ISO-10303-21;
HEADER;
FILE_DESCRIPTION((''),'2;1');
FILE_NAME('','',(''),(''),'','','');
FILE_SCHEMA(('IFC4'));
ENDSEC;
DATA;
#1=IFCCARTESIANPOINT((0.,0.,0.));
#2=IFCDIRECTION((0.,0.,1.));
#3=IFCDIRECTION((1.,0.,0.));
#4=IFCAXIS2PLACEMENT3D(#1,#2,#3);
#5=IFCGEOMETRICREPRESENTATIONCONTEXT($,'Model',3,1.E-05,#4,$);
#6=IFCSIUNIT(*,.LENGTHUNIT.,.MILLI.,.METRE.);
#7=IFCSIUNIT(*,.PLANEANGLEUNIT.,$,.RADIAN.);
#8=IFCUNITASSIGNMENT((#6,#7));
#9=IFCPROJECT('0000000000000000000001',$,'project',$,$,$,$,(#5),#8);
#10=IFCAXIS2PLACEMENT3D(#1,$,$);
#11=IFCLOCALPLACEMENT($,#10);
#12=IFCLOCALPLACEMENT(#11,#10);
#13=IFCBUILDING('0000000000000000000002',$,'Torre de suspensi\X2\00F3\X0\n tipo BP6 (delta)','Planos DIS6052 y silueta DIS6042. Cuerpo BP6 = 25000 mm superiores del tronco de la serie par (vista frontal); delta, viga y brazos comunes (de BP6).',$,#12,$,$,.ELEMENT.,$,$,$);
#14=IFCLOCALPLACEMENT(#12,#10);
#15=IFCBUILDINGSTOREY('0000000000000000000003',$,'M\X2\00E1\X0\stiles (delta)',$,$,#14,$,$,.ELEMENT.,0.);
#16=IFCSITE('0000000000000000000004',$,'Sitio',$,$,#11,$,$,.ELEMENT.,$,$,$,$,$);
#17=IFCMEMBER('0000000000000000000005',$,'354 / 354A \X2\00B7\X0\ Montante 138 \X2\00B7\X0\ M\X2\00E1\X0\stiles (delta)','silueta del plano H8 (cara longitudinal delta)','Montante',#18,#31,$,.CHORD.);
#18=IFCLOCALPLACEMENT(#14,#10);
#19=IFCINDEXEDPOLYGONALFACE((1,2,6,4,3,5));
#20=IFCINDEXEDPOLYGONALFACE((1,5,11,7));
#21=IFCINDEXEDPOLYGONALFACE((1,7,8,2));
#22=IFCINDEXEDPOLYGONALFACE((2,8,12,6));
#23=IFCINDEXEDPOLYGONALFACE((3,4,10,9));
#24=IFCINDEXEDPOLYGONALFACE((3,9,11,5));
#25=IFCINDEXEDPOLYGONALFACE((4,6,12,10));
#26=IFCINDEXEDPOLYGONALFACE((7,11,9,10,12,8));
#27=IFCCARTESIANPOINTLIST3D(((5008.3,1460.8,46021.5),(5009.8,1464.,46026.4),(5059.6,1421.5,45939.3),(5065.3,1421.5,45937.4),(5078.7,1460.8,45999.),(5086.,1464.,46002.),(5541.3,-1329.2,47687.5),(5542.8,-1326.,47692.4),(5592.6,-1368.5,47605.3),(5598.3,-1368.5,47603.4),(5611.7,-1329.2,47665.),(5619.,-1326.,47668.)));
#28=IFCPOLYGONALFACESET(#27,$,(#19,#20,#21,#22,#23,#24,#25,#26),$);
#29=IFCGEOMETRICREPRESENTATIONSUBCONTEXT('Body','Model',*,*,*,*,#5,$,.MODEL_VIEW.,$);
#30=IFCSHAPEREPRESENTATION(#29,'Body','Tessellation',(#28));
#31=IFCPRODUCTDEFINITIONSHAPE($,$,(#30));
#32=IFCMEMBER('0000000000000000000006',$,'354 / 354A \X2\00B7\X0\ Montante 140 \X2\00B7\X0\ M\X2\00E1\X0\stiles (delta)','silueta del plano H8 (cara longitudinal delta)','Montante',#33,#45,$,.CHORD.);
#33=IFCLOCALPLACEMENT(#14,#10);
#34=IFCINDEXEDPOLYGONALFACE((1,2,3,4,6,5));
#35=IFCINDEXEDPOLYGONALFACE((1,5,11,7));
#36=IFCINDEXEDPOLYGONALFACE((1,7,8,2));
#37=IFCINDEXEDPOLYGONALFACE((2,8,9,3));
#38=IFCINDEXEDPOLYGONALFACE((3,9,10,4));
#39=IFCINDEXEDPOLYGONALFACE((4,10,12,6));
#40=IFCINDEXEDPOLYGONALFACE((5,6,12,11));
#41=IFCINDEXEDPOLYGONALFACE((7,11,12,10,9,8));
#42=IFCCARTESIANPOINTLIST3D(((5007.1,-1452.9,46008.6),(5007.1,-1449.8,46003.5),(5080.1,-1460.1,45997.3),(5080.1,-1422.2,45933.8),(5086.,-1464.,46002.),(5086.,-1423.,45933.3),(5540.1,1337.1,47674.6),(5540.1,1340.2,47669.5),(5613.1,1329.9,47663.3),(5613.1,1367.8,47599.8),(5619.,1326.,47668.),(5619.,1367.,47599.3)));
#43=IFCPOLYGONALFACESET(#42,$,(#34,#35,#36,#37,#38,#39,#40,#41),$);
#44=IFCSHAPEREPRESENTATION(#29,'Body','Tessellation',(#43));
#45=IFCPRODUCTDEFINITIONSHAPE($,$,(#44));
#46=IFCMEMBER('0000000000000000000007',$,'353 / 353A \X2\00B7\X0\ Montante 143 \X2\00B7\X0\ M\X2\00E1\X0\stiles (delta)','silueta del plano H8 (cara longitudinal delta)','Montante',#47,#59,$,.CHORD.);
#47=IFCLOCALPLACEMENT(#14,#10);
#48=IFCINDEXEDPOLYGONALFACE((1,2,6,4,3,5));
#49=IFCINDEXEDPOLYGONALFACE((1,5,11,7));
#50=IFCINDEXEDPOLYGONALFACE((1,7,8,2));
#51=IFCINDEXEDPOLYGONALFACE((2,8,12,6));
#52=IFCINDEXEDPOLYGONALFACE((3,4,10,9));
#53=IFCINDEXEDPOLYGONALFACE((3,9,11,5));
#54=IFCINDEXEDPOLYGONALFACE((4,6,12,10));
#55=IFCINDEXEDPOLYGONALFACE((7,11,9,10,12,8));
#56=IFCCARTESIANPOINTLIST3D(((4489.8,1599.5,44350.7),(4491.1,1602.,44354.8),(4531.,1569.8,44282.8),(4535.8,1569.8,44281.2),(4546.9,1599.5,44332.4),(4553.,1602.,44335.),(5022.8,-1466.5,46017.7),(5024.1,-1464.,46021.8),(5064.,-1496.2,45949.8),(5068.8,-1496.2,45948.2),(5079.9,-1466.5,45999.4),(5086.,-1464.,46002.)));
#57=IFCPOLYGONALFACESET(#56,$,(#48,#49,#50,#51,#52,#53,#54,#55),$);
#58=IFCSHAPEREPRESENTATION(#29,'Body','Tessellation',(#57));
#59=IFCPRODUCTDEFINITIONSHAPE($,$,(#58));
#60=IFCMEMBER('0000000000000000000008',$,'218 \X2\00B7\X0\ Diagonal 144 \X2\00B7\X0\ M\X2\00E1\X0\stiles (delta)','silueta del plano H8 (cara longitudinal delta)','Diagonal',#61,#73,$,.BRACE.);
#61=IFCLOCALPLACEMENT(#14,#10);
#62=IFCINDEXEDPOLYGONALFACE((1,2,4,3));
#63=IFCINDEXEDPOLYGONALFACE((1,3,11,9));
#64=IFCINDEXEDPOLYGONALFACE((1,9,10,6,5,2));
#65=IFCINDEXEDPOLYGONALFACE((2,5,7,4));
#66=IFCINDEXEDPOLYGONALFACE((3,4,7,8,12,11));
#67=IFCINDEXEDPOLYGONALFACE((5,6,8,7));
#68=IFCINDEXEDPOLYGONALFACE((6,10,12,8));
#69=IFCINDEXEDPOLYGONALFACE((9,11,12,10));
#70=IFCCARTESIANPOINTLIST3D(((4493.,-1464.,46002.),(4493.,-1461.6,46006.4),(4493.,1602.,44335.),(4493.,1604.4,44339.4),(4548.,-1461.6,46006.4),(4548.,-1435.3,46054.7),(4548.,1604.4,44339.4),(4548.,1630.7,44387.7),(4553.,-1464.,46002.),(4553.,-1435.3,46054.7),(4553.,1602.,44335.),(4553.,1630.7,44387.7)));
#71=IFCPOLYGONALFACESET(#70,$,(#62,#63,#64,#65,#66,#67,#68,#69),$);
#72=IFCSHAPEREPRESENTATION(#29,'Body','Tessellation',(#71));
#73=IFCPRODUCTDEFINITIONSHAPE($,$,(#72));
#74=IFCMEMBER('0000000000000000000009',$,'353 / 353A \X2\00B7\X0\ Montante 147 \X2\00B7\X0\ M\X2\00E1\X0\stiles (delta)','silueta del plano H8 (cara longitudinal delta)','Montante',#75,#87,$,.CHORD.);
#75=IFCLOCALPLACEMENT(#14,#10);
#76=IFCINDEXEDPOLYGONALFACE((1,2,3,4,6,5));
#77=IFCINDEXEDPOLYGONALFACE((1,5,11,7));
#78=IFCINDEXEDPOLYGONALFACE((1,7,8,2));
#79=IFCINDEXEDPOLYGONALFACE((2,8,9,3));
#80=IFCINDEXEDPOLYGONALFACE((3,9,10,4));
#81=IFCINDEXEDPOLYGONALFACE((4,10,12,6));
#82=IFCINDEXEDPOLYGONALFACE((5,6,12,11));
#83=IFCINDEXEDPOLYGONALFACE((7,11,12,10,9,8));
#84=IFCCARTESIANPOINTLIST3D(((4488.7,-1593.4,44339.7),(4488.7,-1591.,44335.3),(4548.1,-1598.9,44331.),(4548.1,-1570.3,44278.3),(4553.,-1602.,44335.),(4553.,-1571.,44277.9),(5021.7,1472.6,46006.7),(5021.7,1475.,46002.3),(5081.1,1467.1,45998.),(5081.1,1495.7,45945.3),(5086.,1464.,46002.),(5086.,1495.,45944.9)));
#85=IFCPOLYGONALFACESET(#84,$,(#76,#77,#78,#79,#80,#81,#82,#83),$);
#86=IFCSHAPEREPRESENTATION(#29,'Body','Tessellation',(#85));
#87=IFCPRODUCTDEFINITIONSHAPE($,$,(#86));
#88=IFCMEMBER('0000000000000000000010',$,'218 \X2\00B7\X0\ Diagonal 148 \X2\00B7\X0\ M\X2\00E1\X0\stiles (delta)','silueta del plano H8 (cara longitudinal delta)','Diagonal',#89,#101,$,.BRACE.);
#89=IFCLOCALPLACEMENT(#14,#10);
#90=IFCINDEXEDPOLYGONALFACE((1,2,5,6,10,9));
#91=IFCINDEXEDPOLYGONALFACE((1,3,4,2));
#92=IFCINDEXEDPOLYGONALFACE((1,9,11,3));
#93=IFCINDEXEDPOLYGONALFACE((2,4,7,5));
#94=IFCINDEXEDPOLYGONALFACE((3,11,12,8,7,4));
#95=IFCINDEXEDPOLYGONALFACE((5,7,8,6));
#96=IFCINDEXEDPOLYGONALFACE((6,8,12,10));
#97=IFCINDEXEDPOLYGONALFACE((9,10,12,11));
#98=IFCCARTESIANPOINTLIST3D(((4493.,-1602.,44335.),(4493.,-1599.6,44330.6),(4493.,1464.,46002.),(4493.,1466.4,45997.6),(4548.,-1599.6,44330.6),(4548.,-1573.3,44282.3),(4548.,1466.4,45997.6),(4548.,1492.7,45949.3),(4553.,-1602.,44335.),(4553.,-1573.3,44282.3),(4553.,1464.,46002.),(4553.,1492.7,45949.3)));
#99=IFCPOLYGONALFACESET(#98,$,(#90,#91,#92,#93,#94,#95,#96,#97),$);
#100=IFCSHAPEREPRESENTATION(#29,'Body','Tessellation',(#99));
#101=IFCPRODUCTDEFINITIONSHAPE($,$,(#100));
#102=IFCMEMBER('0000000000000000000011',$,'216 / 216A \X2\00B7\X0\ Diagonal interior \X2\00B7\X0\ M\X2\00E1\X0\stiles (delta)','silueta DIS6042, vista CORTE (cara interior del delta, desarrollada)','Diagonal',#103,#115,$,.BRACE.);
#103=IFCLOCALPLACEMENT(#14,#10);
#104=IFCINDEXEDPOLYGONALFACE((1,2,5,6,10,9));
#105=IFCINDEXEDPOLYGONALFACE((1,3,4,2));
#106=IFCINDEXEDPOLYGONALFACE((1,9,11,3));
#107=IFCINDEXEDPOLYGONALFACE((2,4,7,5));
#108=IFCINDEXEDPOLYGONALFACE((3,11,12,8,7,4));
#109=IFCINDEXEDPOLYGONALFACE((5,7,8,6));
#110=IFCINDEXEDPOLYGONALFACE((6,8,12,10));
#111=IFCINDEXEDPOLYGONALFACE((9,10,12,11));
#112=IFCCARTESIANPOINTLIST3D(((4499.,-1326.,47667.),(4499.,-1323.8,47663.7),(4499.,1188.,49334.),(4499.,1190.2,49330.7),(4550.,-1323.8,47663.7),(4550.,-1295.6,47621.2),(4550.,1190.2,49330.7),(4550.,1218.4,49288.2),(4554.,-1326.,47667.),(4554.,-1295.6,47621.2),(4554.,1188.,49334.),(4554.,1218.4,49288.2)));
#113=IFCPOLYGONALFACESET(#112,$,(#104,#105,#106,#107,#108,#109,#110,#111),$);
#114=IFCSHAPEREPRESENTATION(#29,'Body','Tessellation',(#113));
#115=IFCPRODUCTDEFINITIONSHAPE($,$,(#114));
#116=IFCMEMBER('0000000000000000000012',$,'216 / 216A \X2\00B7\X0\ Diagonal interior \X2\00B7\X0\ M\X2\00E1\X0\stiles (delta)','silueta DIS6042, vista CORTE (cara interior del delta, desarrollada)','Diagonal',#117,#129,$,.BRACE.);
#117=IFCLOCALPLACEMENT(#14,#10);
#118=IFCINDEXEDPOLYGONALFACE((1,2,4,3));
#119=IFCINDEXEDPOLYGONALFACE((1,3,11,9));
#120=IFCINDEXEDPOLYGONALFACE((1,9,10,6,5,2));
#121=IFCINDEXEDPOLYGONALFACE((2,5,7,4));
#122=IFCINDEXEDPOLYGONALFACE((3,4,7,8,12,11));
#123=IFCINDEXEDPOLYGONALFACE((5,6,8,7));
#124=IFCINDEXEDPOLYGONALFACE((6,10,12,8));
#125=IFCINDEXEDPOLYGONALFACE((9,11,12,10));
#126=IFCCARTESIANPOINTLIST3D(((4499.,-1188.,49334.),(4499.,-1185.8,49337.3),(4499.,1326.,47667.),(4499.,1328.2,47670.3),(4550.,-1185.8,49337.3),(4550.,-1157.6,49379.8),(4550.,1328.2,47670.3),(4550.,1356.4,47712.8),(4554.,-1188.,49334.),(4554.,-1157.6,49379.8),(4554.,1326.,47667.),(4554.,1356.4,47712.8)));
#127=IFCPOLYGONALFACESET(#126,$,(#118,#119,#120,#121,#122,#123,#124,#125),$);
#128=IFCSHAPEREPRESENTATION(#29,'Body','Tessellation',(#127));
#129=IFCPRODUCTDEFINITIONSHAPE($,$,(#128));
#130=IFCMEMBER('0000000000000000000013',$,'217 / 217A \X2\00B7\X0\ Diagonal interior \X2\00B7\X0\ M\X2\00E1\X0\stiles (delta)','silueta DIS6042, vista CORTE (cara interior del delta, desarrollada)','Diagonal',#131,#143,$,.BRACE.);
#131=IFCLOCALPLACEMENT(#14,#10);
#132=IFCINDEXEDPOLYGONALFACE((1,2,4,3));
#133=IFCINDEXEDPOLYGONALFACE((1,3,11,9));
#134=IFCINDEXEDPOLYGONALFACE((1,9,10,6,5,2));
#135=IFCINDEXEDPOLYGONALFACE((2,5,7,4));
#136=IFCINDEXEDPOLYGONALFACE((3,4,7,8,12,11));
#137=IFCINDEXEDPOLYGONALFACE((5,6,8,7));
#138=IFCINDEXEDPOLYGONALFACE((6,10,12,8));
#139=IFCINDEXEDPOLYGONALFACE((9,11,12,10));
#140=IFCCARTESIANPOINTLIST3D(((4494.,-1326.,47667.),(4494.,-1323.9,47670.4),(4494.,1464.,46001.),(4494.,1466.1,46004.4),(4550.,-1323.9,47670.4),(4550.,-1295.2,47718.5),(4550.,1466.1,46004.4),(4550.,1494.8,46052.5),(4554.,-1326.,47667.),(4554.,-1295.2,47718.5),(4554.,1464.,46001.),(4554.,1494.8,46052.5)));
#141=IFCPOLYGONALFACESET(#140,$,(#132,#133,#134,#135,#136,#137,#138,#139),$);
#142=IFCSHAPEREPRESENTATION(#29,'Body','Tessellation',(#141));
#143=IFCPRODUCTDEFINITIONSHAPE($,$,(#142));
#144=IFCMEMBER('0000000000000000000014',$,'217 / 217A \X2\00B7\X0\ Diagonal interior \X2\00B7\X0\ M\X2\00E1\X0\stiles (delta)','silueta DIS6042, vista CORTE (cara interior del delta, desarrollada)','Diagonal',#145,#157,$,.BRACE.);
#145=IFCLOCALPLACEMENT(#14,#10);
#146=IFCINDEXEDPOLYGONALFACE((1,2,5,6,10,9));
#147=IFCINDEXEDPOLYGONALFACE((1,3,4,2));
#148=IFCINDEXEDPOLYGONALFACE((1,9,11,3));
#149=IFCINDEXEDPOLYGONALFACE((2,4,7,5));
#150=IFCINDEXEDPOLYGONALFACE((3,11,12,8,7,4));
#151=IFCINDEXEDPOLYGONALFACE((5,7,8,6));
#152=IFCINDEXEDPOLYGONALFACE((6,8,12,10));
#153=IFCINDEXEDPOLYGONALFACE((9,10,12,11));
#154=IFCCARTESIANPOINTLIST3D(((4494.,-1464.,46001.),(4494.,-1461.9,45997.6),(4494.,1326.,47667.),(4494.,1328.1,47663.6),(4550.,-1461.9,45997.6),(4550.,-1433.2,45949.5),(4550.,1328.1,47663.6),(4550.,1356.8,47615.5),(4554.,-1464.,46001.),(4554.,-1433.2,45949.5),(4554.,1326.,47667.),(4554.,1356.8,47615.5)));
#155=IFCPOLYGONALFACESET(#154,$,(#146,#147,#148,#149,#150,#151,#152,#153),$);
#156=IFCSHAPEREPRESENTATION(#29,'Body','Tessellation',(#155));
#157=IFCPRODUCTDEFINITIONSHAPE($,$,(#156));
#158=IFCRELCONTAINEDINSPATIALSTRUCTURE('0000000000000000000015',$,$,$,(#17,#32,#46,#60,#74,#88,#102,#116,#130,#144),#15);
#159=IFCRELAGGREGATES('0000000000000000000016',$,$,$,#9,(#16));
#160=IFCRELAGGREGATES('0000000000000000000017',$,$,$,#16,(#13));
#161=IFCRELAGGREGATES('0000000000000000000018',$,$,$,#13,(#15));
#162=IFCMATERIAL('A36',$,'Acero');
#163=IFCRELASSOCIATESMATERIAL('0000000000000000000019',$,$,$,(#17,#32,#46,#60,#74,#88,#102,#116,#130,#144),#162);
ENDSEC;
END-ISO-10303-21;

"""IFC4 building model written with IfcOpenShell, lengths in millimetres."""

from ifc_helpers import new_model, si_unit, frame, frame_2d, origin, origin_with_axes, place, context, subcontext, project, spatial, l_section, extrude, material, element, save


model = new_model("IFC4")

# Units and contexts
model_context = context("Model", 3, precision=1e-05, world=origin_with_axes())
body_context = subcontext(model_context, "Body", "Model", "MODEL_VIEW")
ifc_project = project(units=[si_unit("LENGTHUNIT", "METRE", prefix="MILLI"), si_unit("PLANEANGLEUNIT", "RADIAN")], contexts=[model_context])

# Site, building, storey
site_placement = place(None, origin())
site = spatial("IfcSite", under=ifc_project, at=site_placement, Name="Sitio", CompositionType="ELEMENT")
building_placement = place(site_placement, origin())
building = spatial("IfcBuilding", under=site, at=building_placement, Name="Torre de suspensión tipo BP6 (delta)", Description="Planos DIS6052 y silueta DIS6042. Cuerpo BP6 = 25000 mm superiores del tronco de la serie par (vista frontal); delta, viga y brazos comunes (de BP6).", CompositionType="ELEMENT")
storey_placement = place(building_placement, origin())
storey = spatial("IfcBuildingStorey", under=building, at=storey_placement, Name="Mástiles (delta)", CompositionType="ELEMENT", Elevation=0.0)

# Members
ifc_material_1 = material(Name="A36", Category="Acero")
for number, where, z_axis, x_axis, name in (
    (1, (5619.0, -1326.0, 47668.0), (-0.161859, 0.847256, -0.505924), (-0.25817, -0.531185, -0.806964), "354 / 354A · Montante 138 · Mástiles (delta)"),
    (2, (5619.0, 1326.0, 47668.0), (-0.161859, -0.847256, -0.505924), (-0.986814, 0.138969, 0.082983), "354 / 354A · Montante 140 · Mástiles (delta)"),
):
    element("IfcMember", number, at=place(storey_placement, frame(where, z_axis=z_axis, x_axis=x_axis)), inside=storey, material=ifc_material_1, Name=name, Description="silueta del plano H8 (cara longitudinal delta)", ObjectType="Montante", PredefinedType="CHORD", context=body_context, shape_type="SweptSolid", body=[
        extrude(l_section(Depth=80.0, Width=80.0, Thickness=6.0, at=frame_2d((40.0, 40.0))), None, (0.0, 0.0, 1.0), 3293.0),
    ])
member_1_placement = place(storey_placement, frame((5086.0, -1464.0, 46002.0), z_axis=(-0.150977, 0.86847, -0.472192), x_axis=(-0.264491, -0.495741, -0.827216)))
element("IfcMember", 3, at=member_1_placement, inside=storey, material=ifc_material_1, Name="353 / 353A · Montante 143 · Mástiles (delta)", Description="silueta del plano H8 (cara longitudinal delta)", ObjectType="Montante", PredefinedType="CHORD", context=body_context, shape_type="SweptSolid", body=[
    extrude(l_section(Depth=65.0, Width=65.0, Thickness=5.0, at=frame_2d((32.5, 32.5))), None, (0.0, 0.0, 1.0), 3530.3),
])
member_2_placement = place(storey_placement, frame((4553.0, -1464.0, 46002.0), z_axis=(0.0, 0.878541, -0.477667), x_axis=(-1.0, 0.0, 0.0)))
element("IfcMember", 4, at=member_2_placement, inside=storey, material=ifc_material_1, Name="218 · Diagonal 144 · Mástiles (delta)", Description="silueta del plano H8 (cara longitudinal delta)", ObjectType="Diagonal", PredefinedType="BRACE", context=body_context, shape_type="SweptSolid", body=[
    extrude(l_section(Depth=60.0, Width=60.0, Thickness=5.0, at=frame_2d((30.0, 30.0))), None, (0.0, 0.0, 1.0), 3489.9),
])
member_3_placement = place(storey_placement, frame((5086.0, 1464.0, 46002.0), z_axis=(-0.150977, -0.86847, -0.472192), x_axis=(-0.988537, 0.132639, 0.072117)))
element("IfcMember", 5, at=member_3_placement, inside=storey, material=ifc_material_1, Name="353 / 353A · Montante 147 · Mástiles (delta)", Description="silueta del plano H8 (cara longitudinal delta)", ObjectType="Montante", PredefinedType="CHORD", context=body_context, shape_type="SweptSolid", body=[
    extrude(l_section(Depth=65.0, Width=65.0, Thickness=5.0, at=frame_2d((32.5, 32.5))), None, (0.0, 0.0, 1.0), 3530.3),
])
member_4_placement = place(storey_placement, frame((4553.0, 1464.0, 46002.0), z_axis=(0.0, -0.878541, -0.477667), x_axis=(-1.0, 0.0, 0.0)))
element("IfcMember", 6, at=member_4_placement, inside=storey, material=ifc_material_1, Name="218 · Diagonal 148 · Mástiles (delta)", Description="silueta del plano H8 (cara longitudinal delta)", ObjectType="Diagonal", PredefinedType="BRACE", context=body_context, shape_type="SweptSolid", body=[
    extrude(l_section(Depth=60.0, Width=60.0, Thickness=5.0, at=frame_2d((30.0, 30.0))), None, (0.0, 0.0, 1.0), 3489.9),
])
for number, where, z_axis, x_axis, name in (
    (7, (4554.0, 1188.0, 49334.0), (0.0, -0.833425, -0.552633), (-1.0, 0.0, 0.0), "216 / 216A · Diagonal interior · Mástiles (delta)"),
    (8, (4554.0, -1188.0, 49334.0), (0.0, 0.833425, -0.552633), (-1.0, 0.0, 0.0), "216 / 216A · Diagonal interior · Mástiles (delta)"),
):
    element("IfcMember", number, at=place(storey_placement, frame(where, z_axis=z_axis, x_axis=x_axis)), inside=storey, material=ifc_material_1, Name=name, Description="silueta DIS6042, vista CORTE (cara interior del delta, desarrollada)", ObjectType="Diagonal", PredefinedType="BRACE", context=body_context, shape_type="SweptSolid", body=[
        extrude(l_section(Depth=55.0, Width=55.0, Thickness=4.0, at=frame_2d((27.5, 27.5))), None, (0.0, 0.0, 1.0), 3016.5),
    ])
for number, where, z_axis, x_axis, name in (
    (9, (4554.0, -1326.0, 47667.0), (0.0, 0.858577, -0.512684), (-1.0, 0.0, 0.0), "217 / 217A · Diagonal interior · Mástiles (delta)"),
    (10, (4554.0, 1326.0, 47667.0), (0.0, -0.858577, -0.512684), (-1.0, 0.0, 0.0), "217 / 217A · Diagonal interior · Mástiles (delta)"),
):
    element("IfcMember", number, at=place(storey_placement, frame(where, z_axis=z_axis, x_axis=x_axis)), inside=storey, material=ifc_material_1, Name=name, Description="silueta DIS6042, vista CORTE (cara interior del delta, desarrollada)", ObjectType="Diagonal", PredefinedType="BRACE", context=body_context, shape_type="SweptSolid", body=[
        extrude(l_section(Depth=60.0, Width=60.0, Thickness=4.0, at=frame_2d((30.0, 30.0))), None, (0.0, 0.0, 1.0), 3249.6),
    ])

save(model, "model.ifc")
